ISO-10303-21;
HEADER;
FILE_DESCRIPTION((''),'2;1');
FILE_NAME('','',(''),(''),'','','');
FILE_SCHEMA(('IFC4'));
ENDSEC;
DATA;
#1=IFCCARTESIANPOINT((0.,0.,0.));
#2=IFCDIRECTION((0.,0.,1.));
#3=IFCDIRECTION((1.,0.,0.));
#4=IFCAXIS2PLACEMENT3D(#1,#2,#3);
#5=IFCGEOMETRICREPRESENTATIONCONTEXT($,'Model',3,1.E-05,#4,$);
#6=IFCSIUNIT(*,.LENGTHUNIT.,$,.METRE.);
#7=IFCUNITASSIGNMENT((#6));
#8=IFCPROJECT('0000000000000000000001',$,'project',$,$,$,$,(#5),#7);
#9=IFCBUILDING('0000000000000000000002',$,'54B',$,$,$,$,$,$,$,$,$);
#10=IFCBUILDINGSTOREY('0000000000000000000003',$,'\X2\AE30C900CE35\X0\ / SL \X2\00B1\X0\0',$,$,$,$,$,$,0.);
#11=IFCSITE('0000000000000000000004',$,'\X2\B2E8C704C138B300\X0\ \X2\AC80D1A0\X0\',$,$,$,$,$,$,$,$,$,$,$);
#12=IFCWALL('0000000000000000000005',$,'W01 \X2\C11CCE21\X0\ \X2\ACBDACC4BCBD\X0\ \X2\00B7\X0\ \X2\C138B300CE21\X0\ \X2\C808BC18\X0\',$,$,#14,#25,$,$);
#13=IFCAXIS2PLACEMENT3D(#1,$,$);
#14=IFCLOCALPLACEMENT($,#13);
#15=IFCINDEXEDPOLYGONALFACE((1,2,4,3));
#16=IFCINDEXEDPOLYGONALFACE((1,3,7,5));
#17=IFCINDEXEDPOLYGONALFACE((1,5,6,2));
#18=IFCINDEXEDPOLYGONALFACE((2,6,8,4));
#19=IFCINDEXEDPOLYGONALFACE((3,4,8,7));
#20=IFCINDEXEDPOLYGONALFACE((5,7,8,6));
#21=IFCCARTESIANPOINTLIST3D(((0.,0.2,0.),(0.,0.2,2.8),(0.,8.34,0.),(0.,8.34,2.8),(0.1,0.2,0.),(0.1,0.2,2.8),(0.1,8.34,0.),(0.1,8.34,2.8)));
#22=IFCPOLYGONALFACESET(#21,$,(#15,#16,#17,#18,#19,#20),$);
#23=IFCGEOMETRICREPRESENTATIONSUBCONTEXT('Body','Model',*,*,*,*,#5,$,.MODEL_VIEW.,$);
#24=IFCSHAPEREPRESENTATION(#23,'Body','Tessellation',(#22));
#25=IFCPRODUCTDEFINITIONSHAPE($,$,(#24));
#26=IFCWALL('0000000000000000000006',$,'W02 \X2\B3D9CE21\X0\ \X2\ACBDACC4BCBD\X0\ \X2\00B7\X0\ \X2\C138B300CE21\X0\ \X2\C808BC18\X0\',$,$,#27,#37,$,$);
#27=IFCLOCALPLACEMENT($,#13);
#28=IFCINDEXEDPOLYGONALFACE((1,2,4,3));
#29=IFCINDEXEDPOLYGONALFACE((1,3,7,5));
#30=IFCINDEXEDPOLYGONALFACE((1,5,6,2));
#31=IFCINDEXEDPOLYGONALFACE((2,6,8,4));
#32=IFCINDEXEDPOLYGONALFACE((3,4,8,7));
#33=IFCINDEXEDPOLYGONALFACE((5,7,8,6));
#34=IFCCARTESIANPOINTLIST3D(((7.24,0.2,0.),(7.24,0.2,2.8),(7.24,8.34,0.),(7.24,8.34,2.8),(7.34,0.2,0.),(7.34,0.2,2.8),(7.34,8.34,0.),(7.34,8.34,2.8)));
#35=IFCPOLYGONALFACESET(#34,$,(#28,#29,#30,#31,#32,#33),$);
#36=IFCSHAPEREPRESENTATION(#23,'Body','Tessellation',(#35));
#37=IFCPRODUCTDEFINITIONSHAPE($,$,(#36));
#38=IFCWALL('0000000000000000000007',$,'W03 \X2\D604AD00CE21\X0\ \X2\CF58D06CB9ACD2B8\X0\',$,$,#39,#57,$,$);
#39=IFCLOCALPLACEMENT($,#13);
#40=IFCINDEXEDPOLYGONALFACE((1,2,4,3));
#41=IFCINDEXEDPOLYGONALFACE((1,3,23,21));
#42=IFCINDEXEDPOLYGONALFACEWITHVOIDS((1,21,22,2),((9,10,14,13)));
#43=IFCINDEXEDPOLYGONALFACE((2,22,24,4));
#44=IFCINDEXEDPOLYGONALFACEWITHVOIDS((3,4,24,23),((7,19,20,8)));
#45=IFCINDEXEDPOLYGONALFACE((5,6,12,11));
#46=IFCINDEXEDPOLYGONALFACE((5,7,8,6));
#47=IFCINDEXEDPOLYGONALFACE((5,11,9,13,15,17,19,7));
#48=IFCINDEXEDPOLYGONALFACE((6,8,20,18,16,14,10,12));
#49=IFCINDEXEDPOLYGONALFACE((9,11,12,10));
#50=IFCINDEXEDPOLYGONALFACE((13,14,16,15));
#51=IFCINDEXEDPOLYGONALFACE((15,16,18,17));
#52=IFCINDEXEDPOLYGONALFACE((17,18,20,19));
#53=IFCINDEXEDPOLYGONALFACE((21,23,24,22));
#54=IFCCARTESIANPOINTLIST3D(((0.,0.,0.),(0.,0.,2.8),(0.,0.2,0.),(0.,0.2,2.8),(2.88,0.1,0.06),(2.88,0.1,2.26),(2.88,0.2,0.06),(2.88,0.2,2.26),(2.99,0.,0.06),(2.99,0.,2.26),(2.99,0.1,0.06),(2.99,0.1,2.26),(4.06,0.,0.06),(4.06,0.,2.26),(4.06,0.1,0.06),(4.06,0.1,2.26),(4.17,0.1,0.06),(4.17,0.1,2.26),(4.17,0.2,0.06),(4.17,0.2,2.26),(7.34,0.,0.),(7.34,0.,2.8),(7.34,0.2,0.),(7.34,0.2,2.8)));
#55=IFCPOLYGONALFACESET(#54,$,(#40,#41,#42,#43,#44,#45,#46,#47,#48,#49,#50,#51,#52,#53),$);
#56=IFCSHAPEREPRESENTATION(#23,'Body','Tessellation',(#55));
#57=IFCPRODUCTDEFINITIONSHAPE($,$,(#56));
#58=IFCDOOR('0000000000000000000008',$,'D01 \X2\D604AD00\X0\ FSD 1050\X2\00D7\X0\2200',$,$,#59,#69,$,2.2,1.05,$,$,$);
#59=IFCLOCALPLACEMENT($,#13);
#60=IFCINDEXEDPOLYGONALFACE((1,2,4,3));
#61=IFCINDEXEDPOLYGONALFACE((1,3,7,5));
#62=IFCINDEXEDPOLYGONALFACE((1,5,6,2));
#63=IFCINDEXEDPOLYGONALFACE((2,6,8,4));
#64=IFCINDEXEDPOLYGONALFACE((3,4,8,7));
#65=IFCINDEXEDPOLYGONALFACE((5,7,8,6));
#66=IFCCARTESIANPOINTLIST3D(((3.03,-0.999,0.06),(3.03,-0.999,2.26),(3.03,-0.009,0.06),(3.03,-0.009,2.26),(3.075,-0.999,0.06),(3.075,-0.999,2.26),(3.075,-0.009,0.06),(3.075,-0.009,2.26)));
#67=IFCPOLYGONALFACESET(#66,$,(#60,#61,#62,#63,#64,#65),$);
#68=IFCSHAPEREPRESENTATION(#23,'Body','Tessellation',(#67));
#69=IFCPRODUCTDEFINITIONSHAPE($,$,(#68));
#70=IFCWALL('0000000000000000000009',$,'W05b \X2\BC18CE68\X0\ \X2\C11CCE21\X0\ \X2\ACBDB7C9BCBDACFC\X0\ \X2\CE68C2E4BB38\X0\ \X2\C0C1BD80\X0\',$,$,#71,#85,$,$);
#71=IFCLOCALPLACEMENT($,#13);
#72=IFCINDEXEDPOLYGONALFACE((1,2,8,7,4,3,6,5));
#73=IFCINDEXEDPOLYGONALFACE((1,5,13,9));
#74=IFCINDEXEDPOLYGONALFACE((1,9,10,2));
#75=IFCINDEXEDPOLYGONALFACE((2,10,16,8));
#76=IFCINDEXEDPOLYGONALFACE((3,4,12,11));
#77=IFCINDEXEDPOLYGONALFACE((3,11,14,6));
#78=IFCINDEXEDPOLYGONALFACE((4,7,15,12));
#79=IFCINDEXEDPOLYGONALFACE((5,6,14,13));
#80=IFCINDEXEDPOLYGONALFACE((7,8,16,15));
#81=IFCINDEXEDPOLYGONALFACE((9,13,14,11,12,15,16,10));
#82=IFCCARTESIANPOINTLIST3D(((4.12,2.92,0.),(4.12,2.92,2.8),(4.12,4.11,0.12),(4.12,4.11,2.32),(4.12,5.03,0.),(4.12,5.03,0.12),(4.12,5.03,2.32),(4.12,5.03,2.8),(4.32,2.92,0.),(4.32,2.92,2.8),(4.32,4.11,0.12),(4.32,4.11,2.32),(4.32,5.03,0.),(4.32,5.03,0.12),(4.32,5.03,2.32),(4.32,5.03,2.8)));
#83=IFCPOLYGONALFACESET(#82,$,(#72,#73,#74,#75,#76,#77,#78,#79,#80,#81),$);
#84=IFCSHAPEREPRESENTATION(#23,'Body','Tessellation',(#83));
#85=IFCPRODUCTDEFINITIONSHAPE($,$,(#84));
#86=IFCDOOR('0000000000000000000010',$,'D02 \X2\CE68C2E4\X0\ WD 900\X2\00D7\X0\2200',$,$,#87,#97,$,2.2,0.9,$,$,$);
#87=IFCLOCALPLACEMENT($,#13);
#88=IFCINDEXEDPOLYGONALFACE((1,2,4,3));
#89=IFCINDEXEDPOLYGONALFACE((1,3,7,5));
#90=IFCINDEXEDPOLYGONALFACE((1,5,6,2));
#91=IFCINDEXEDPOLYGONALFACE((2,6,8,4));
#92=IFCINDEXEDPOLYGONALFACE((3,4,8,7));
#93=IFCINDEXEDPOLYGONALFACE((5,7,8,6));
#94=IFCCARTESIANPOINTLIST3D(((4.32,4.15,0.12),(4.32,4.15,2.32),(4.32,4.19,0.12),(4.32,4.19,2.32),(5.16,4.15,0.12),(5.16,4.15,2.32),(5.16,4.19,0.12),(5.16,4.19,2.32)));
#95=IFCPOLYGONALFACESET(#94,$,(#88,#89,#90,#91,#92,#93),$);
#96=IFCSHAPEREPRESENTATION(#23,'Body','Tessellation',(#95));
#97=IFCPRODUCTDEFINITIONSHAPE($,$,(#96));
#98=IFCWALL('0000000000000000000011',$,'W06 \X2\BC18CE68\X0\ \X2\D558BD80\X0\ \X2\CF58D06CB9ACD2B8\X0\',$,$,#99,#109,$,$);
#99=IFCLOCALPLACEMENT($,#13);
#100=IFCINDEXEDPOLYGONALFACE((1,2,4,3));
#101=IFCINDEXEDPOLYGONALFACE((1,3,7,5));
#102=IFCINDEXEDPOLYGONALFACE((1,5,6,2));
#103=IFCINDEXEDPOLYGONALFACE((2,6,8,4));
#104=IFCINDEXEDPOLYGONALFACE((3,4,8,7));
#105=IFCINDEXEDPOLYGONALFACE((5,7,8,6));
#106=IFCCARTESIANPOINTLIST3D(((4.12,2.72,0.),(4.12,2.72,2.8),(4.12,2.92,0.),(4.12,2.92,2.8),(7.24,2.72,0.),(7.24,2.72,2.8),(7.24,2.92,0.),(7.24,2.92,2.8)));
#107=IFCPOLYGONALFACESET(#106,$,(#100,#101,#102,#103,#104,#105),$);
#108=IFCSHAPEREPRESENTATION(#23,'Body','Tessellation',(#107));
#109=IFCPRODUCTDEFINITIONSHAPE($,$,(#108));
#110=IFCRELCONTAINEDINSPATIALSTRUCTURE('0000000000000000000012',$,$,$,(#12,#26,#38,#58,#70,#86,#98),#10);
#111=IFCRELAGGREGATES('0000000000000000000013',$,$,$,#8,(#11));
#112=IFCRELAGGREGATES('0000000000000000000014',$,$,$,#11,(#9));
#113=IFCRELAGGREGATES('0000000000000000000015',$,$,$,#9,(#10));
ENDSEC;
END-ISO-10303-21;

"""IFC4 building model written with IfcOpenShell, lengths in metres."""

from ifc_helpers import new_model, si_unit, frame, origin, origin_with_axes, place, context, subcontext, project, spatial, polyline, outline, extrude, element, fill, save


model = new_model("IFC4")

# Units and contexts
model_context = context("Model", 3, precision=1e-05, world=origin_with_axes())
body_context = subcontext(model_context, "Body", "Model", "MODEL_VIEW")
ifc_project = project(units=[si_unit("LENGTHUNIT", "METRE")], contexts=[model_context])

# Site, building, storey
site = spatial("IfcSite", under=ifc_project, Name="단위세대 검토")
building = spatial("IfcBuilding", under=site, Name="54B")
storey = spatial("IfcBuildingStorey", under=building, Name="기준층 / SL ±0", Elevation=0.0)

# Walls
wall_1_placement = place(None, origin_with_axes())
element("IfcWall", 1, at=wall_1_placement, inside=storey, Name="W01 서측 경계벽 · 세대측 절반", context=body_context, shape_type="SweptSolid", body=[
    extrude(outline(polyline([(0.1, 0.2), (0.1, 8.34), (0.0, 8.34), (0.0, 0.2), (0.1, 0.2)])), origin(), (0.0, 0.0, 1.0), 2.8),
])
wall_2_placement = place(None, origin_with_axes())
element("IfcWall", 2, at=wall_2_placement, inside=storey, Name="W02 동측 경계벽 · 세대측 절반", context=body_context, shape_type="SweptSolid", body=[
    extrude(outline(polyline([(7.34, 0.2), (7.34, 8.34), (7.24, 8.34), (7.24, 0.2), (7.34, 0.2)])), origin(), (0.0, 0.0, 1.0), 2.8),
])

# Wall, opening, door
wall_3_placement = place(None, origin_with_axes())
wall_3 = element("IfcWall", 3, at=wall_3_placement, inside=storey, Name="W03 현관측 콘크리트", context=body_context, shape_type="SweptSolid", body=[
    extrude(outline(polyline([(7.34, 0.0), (7.34, 0.2), (0.0, 0.2), (0.0, 0.0), (7.34, 0.0)])), origin(), (0.0, 0.0, 1.0), 2.8),
])
opening_1_placement = place(wall_3_placement, origin_with_axes())
opening_1 = element("IfcOpeningElement", 4, at=opening_1_placement, cuts=wall_3, context=body_context, shape_type="SweptSolid", body=[
    extrude(outline(polyline([(2.99, -0.001), (4.06, -0.001), (4.06, 0.1), (4.17, 0.1), (4.17, 0.201), (2.88, 0.201), (2.88, 0.1), (2.99, 0.1), (2.99, -0.001)])), frame((0.0, 0.0, 0.06)), (0.0, 0.0, 1.0), 2.2),
])
door_1_placement = place(None, origin_with_axes())
door_1 = element("IfcDoor", 5, at=door_1_placement, inside=storey, Name="D01 현관 FSD 1050×2200", OverallHeight=2.2, OverallWidth=1.05, context=body_context, shape_type="SweptSolid", body=[
    extrude(outline(polyline([(3.075, -0.009), (3.075, -0.999), (3.03, -0.999), (3.03, -0.009), (3.075, -0.009)])), frame((0.0, 0.0, 0.06)), (0.0, 0.0, 1.0), 2.2),
])
fill(opening_1, door_1)

# Wall, opening, door
wall_4_placement = place(None, origin_with_axes())
wall_4 = element("IfcWall", 6, at=wall_4_placement, inside=storey, Name="W05b 반침 서측 경량벽과 침실문 상부", context=body_context, shape_type="SweptSolid", body=[
    extrude(outline(polyline([(4.12, 2.92), (4.32, 2.92), (4.32, 5.03), (4.12, 5.03), (4.12, 2.92)])), origin(), (0.0, 0.0, 1.0), 2.8),
])
opening_2_placement = place(wall_4_placement, origin_with_axes())
opening_2 = element("IfcOpeningElement", 7, at=opening_2_placement, cuts=wall_4, context=body_context, shape_type="SweptSolid", body=[
    extrude(outline(polyline([(4.321, 4.11), (4.321, 5.03), (4.119, 5.03), (4.119, 4.11), (4.321, 4.11)])), frame((0.0, 0.0, 0.12)), (0.0, 0.0, 1.0), 2.2),
])
door_2_placement = place(None, origin_with_axes())
door_2 = element("IfcDoor", 8, at=door_2_placement, inside=storey, Name="D02 침실 WD 900×2200", OverallHeight=2.2, OverallWidth=0.9, context=body_context, shape_type="SweptSolid", body=[
    extrude(outline(polyline([(4.32, 4.19), (4.32, 4.15), (5.16, 4.15), (5.16, 4.19), (4.32, 4.19)])), frame((0.0, 0.0, 0.12)), (0.0, 0.0, 1.0), 2.2),
])
fill(opening_2, door_2)

# Wall
wall_5_placement = place(None, origin_with_axes())
element("IfcWall", 9, at=wall_5_placement, inside=storey, Name="W06 반침 하부 콘크리트", context=body_context, shape_type="SweptSolid", body=[
    extrude(outline(polyline([(7.24, 2.72), (7.24, 2.92), (4.12, 2.92), (4.12, 2.72), (7.24, 2.72)])), origin(), (0.0, 0.0, 1.0), 2.8),
])

save(model, "model.ifc")
